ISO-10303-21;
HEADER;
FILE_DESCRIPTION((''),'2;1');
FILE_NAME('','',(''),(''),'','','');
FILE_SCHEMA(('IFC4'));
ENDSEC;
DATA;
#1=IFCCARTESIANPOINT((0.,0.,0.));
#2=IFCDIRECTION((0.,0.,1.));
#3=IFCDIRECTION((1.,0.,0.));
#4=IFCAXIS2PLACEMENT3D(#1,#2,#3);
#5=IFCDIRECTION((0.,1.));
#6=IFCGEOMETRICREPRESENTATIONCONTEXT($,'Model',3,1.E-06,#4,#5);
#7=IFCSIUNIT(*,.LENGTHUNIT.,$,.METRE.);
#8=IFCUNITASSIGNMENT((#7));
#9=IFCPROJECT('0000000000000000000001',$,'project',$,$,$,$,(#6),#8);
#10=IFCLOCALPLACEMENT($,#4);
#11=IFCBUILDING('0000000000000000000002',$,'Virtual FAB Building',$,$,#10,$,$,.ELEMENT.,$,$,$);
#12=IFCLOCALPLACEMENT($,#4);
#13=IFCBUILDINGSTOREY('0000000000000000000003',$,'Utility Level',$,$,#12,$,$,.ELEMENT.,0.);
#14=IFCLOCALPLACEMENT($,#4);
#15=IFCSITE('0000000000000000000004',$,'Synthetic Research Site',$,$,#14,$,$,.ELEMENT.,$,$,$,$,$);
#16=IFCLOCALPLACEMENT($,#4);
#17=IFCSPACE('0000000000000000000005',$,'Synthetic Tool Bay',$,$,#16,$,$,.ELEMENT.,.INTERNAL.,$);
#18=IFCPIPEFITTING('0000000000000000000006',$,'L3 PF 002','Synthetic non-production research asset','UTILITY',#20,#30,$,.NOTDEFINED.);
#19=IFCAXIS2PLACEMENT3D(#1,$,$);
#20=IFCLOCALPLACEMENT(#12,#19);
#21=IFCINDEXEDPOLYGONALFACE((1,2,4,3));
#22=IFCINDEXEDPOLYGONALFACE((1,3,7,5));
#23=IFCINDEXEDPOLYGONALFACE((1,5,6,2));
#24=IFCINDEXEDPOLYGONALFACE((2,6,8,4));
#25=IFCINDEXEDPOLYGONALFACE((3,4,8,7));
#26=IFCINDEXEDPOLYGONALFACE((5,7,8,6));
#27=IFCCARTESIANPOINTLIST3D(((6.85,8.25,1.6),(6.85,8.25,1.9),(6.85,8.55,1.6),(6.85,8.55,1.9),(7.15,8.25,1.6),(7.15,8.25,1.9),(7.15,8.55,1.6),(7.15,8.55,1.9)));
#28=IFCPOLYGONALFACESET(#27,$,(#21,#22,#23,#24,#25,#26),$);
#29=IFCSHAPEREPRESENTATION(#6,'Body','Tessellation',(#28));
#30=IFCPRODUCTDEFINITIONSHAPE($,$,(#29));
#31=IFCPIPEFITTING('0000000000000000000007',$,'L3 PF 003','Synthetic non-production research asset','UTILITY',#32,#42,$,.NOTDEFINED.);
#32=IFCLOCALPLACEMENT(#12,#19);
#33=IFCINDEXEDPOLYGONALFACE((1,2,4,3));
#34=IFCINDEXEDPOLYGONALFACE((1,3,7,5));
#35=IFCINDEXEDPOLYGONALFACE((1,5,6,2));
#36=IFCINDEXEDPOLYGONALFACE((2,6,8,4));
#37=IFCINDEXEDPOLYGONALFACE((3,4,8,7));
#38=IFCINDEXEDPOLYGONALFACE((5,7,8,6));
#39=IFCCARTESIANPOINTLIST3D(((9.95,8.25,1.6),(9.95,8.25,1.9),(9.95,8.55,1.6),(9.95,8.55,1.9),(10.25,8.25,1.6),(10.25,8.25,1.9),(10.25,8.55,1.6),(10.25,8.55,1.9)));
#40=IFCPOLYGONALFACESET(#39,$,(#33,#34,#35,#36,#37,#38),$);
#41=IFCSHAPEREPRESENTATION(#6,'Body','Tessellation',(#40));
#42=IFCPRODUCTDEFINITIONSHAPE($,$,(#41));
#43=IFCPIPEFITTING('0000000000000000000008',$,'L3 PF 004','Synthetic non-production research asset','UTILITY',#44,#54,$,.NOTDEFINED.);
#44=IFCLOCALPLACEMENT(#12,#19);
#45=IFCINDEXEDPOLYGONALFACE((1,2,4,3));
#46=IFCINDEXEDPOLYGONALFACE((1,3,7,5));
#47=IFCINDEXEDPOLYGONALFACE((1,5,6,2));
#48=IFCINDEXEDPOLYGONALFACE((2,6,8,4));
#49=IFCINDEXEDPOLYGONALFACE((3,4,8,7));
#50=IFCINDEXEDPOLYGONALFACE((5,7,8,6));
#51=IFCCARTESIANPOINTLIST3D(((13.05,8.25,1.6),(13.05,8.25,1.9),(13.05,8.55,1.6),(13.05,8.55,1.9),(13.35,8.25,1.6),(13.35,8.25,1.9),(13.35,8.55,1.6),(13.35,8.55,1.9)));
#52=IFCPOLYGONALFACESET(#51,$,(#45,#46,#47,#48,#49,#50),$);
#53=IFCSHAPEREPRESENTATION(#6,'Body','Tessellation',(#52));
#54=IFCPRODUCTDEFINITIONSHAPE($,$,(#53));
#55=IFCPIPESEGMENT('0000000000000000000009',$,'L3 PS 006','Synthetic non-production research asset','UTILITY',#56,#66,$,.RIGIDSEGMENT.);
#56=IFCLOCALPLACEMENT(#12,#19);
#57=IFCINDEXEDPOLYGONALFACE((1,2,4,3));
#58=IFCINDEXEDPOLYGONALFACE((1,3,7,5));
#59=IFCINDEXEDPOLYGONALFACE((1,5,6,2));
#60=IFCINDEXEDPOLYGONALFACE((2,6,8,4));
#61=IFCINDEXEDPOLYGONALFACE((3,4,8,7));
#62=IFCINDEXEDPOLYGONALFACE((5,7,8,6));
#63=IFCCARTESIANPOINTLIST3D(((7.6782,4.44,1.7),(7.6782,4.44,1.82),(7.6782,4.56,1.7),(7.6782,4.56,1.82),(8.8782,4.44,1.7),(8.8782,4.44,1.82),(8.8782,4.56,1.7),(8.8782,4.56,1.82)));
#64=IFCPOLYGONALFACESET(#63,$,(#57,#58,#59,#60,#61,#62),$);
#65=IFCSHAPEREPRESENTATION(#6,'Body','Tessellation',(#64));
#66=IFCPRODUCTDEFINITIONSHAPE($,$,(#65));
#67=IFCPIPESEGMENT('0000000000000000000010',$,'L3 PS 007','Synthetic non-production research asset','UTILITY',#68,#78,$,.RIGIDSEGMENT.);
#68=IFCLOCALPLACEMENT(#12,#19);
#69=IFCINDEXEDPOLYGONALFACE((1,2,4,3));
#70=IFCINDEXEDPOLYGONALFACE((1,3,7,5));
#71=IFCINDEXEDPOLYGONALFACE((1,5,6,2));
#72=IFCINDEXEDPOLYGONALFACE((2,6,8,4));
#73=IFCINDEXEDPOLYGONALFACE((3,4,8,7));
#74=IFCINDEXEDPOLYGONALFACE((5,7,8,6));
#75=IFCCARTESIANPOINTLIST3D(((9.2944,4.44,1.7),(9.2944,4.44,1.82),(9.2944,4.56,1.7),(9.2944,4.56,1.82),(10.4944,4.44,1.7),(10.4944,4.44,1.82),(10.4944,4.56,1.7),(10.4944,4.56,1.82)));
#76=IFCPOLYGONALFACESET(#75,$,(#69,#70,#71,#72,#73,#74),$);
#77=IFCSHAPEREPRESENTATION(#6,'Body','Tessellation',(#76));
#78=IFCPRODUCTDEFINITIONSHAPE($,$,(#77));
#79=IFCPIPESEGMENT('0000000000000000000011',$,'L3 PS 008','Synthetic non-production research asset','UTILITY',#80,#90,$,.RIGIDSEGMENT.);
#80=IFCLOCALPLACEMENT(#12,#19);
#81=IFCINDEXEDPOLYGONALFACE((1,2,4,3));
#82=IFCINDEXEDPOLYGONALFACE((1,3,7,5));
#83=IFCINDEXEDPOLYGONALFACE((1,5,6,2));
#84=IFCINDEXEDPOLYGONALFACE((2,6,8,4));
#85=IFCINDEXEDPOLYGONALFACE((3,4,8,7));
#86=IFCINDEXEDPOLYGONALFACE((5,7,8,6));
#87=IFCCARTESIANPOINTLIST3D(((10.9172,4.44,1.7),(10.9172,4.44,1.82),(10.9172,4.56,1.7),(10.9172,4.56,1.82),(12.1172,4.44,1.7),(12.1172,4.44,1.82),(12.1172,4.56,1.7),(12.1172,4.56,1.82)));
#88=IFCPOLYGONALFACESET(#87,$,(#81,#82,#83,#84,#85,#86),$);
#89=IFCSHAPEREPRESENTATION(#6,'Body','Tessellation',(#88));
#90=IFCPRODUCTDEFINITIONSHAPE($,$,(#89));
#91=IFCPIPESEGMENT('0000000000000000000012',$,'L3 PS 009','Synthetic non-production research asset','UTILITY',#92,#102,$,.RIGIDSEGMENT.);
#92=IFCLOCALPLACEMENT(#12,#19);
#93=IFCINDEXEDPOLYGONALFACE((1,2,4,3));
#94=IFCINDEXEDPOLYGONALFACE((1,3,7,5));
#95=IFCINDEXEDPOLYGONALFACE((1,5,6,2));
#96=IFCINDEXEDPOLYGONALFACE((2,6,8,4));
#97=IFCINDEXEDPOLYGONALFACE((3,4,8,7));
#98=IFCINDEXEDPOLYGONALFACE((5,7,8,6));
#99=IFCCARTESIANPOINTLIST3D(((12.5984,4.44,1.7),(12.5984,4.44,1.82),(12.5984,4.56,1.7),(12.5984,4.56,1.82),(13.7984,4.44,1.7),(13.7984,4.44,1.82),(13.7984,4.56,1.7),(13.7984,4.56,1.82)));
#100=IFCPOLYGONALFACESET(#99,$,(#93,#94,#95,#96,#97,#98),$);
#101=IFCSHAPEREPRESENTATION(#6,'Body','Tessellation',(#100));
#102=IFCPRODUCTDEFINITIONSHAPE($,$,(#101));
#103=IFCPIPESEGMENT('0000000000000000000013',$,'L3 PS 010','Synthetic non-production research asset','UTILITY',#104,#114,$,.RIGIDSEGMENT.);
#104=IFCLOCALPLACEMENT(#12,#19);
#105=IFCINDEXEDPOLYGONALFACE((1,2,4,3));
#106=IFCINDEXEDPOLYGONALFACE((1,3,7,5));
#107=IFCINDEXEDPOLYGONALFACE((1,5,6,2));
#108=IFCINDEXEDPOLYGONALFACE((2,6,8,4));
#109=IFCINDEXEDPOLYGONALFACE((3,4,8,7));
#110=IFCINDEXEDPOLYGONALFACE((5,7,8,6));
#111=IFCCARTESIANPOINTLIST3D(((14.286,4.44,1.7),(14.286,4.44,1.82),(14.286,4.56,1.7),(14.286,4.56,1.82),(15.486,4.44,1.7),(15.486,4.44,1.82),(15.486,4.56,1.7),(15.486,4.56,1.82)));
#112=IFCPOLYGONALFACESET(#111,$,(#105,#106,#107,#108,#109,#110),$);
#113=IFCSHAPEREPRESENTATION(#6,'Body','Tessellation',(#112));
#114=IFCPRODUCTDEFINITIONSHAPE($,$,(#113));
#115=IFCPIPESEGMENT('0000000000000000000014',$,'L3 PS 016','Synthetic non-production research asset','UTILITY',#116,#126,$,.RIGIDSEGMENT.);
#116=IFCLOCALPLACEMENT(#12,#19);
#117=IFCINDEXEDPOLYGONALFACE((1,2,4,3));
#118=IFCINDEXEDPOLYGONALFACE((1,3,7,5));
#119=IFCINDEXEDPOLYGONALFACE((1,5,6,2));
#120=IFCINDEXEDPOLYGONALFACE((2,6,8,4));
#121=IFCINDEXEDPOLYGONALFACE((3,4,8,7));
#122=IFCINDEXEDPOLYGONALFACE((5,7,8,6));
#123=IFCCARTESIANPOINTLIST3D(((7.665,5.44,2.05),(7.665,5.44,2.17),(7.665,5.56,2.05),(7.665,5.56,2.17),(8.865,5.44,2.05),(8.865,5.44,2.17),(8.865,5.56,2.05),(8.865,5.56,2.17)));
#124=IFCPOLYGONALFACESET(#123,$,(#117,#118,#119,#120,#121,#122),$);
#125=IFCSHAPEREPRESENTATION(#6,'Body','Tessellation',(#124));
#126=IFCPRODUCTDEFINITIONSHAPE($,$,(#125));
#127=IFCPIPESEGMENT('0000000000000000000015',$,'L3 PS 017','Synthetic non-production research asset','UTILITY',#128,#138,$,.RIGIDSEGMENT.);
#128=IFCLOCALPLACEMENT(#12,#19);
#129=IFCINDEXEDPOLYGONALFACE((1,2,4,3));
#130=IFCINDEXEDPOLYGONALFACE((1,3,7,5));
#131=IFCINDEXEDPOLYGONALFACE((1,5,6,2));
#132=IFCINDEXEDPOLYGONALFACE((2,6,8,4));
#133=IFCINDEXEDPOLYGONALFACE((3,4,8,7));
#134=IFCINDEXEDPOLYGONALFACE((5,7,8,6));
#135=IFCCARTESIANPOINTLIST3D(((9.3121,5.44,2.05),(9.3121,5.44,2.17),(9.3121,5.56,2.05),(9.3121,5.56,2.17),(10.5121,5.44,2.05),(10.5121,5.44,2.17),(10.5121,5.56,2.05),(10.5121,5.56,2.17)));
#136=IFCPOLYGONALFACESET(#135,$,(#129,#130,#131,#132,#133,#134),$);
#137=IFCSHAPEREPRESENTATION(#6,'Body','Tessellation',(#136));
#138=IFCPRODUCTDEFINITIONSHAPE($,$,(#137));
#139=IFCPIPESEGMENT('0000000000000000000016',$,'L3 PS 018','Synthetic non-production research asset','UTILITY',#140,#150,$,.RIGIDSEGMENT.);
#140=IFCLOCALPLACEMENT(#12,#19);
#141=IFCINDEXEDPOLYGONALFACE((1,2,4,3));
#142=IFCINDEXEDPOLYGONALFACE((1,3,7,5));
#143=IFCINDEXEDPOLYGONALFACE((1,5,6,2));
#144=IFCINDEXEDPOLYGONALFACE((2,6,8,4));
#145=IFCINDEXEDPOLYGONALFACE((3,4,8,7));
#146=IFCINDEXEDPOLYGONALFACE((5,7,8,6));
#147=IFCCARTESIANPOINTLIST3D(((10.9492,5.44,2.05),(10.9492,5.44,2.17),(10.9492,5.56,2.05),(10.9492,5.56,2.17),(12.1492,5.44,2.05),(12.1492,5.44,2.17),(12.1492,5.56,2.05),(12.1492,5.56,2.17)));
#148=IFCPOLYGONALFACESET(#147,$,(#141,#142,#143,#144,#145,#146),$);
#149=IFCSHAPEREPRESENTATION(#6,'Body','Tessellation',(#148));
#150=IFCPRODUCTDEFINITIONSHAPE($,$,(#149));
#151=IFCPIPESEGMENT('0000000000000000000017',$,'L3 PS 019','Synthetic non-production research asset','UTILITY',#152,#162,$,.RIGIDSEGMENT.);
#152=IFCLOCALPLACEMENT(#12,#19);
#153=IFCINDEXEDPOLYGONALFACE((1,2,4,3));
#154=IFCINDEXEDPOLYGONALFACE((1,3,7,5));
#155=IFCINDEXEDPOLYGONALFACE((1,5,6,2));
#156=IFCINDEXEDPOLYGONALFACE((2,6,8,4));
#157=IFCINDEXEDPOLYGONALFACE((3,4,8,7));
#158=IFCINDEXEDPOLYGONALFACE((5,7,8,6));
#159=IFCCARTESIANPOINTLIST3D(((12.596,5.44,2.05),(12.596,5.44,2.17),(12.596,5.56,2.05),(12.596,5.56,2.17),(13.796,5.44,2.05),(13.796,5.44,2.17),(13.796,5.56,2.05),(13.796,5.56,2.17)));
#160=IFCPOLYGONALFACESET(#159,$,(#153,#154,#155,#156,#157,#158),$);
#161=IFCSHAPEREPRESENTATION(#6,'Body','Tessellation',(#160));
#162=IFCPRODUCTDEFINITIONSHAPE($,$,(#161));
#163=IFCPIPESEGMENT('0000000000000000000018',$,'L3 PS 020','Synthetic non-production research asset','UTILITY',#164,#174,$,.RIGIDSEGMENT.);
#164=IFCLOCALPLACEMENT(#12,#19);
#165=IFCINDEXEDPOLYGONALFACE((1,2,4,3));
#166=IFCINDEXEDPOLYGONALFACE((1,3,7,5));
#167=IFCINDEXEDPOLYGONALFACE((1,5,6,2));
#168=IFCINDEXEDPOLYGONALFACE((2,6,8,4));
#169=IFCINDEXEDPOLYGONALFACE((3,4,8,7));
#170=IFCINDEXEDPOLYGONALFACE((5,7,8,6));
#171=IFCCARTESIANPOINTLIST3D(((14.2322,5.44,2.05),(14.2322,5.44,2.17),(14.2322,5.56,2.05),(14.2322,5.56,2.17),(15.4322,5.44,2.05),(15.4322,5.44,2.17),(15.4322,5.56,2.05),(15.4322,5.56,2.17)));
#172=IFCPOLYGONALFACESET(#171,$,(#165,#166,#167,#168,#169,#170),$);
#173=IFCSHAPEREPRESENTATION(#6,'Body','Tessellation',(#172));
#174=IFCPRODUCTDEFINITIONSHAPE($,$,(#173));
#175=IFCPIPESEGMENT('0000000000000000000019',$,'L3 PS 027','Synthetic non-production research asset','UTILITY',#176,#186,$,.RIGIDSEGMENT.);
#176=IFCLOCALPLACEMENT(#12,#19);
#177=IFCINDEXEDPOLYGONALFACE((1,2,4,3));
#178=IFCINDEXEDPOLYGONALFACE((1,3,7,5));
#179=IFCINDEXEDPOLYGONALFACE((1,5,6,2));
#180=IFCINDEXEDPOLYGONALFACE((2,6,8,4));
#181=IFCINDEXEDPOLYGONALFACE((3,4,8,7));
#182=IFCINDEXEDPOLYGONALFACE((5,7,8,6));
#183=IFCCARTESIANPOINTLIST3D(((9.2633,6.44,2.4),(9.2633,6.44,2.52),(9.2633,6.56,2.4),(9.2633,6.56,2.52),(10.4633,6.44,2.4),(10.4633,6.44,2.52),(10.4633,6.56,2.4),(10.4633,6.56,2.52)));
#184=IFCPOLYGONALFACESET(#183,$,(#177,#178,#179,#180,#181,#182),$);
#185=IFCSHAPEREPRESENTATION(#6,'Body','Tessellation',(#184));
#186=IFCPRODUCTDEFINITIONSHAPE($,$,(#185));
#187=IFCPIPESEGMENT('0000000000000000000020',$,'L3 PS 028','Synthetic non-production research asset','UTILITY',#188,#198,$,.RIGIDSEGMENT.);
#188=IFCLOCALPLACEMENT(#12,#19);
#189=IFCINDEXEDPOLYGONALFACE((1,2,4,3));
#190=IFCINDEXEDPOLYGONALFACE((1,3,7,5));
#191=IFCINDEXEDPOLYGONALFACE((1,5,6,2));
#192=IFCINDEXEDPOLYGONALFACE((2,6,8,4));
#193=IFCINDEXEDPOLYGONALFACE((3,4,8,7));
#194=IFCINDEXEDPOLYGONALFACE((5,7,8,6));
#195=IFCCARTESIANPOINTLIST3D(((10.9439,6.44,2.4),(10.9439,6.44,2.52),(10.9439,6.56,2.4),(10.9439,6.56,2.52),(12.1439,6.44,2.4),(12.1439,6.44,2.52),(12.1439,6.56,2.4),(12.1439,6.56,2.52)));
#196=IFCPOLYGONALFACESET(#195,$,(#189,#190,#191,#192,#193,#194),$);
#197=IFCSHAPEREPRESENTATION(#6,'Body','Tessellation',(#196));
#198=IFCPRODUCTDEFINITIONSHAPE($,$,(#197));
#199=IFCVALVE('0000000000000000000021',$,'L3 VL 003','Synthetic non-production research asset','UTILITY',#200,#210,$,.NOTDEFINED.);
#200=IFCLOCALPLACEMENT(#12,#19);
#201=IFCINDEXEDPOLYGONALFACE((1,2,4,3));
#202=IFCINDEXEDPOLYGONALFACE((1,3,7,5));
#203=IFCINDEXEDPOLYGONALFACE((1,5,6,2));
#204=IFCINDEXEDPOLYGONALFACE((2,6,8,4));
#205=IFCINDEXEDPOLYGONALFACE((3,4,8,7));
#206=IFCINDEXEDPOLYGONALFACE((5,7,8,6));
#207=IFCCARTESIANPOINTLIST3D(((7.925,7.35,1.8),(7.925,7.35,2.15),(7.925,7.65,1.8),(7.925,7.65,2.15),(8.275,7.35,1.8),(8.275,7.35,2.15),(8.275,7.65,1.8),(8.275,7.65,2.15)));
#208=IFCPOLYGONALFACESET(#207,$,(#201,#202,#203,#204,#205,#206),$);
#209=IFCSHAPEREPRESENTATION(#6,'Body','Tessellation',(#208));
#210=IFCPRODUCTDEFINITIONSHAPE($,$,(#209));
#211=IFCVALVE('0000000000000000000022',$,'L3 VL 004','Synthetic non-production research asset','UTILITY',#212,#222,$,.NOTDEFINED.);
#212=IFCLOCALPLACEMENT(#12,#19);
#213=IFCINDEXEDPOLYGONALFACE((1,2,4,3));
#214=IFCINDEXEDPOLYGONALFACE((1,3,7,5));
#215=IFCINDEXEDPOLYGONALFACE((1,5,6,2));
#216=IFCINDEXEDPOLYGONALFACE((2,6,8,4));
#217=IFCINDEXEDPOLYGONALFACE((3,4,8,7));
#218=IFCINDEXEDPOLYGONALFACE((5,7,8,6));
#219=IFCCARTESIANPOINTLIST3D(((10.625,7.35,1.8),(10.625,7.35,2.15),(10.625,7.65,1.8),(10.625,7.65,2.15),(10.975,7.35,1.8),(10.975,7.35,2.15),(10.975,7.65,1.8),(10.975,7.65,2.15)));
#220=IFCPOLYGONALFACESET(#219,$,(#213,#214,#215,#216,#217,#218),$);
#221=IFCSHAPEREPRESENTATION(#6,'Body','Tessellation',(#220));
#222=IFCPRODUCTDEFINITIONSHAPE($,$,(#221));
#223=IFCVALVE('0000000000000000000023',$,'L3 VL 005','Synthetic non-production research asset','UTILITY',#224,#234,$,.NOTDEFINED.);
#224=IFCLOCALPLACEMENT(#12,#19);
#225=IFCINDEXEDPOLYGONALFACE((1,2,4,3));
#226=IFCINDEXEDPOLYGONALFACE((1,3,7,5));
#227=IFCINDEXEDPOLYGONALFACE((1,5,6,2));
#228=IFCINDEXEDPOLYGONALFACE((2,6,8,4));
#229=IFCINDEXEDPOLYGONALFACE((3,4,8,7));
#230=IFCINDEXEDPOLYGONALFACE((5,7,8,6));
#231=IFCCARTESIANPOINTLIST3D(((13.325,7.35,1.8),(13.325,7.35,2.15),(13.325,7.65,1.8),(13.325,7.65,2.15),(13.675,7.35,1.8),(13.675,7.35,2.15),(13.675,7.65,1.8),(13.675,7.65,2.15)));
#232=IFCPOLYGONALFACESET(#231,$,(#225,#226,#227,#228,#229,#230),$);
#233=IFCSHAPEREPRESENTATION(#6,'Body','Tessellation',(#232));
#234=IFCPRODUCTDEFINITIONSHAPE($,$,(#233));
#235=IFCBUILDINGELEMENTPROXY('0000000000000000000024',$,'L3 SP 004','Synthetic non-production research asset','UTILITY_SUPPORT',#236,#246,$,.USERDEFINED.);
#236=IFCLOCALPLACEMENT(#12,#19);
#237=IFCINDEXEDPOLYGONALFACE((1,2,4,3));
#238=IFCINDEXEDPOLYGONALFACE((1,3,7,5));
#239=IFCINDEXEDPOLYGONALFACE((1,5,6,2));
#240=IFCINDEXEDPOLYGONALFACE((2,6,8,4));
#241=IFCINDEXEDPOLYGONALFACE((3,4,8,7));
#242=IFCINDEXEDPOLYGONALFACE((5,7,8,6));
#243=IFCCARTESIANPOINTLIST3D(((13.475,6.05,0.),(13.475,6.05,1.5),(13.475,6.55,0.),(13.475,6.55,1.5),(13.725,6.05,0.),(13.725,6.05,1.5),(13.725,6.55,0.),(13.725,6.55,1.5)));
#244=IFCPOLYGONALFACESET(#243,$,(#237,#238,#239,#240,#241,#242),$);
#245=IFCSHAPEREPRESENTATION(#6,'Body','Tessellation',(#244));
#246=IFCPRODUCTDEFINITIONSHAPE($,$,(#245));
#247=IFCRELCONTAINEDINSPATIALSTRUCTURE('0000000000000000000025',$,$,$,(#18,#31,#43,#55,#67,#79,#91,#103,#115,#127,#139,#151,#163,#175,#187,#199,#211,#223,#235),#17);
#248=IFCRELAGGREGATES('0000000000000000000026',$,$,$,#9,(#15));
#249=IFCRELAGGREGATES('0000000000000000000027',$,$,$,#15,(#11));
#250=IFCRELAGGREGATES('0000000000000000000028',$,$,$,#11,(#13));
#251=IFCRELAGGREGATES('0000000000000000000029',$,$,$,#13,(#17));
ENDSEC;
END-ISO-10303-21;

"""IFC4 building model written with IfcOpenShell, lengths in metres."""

from ifc_helpers import new_model, si_unit, direction, frame, origin_with_axes, origin_2d_with_axis, place, context, project, spatial, rectangle, extrude, element, save


model = new_model("IFC4")

# Units and contexts
model_context = context("Model", 3, precision=1e-06, world=origin_with_axes(), true_north=direction((0.0, 1.0)))
ifc_project = project(units=[si_unit("LENGTHUNIT", "METRE")], contexts=[model_context])

# Site, building, storey, space
site_placement = place(None, origin_with_axes())
site = spatial("IfcSite", under=ifc_project, at=site_placement, Name="Synthetic Research Site", CompositionType="ELEMENT")
building_placement = place(None, origin_with_axes())
building = spatial("IfcBuilding", under=site, at=building_placement, Name="Virtual FAB Building", CompositionType="ELEMENT")
storey_placement = place(None, origin_with_axes())
storey = spatial("IfcBuildingStorey", under=building, at=storey_placement, Name="Utility Level", CompositionType="ELEMENT", Elevation=0.0)
space_placement = place(None, origin_with_axes())
space = spatial("IfcSpace", under=storey, at=space_placement, Name="Synthetic Tool Bay", CompositionType="ELEMENT", PredefinedType="INTERNAL")

# Pipe fittings
for number, where, z_axis, x_axis, name in (
    (1, (7.0, 8.4, 1.6), (0.0, 0.0, 1.0), (1.0, 0.0, 0.0), "L3 PF 002"),
    (2, (10.1, 8.4, 1.6), (0.0, 0.0, 1.0), (1.0, 0.0, 0.0), "L3 PF 003"),
    (3, (13.2, 8.4, 1.6), (0.0, 0.0, 1.0), (1.0, 0.0, 0.0), "L3 PF 004"),
):
    element("IfcPipeFitting", number, at=place(None, frame(where, z_axis=z_axis, x_axis=x_axis)), inside=space, Name=name, Description="Synthetic non-production research asset", ObjectType="UTILITY", PredefinedType="NOTDEFINED", context=model_context, shape_type="SweptSolid", body=[
        extrude(rectangle(XDim=0.3, YDim=0.3, at=origin_2d_with_axis()), origin_with_axes(), (0.0, 0.0, 1.0), 0.3),
    ])

# Pipe segments
for number, where, z_axis, x_axis, name in (
    (4, (8.2782, 4.5, 1.7), (0.0, 0.0, 1.0), (1.0, 0.0, 0.0), "L3 PS 006"),
    (5, (9.8944, 4.5, 1.7), (0.0, 0.0, 1.0), (1.0, 0.0, 0.0), "L3 PS 007"),
    (6, (11.5172, 4.5, 1.7), (0.0, 0.0, 1.0), (1.0, 0.0, 0.0), "L3 PS 008"),
    (7, (13.1984, 4.5, 1.7), (0.0, 0.0, 1.0), (1.0, 0.0, 0.0), "L3 PS 009"),
    (8, (14.886, 4.5, 1.7), (0.0, 0.0, 1.0), (1.0, 0.0, 0.0), "L3 PS 010"),
    (9, (8.265, 5.5, 2.05), (0.0, 0.0, 1.0), (1.0, 0.0, 0.0), "L3 PS 016"),
    (10, (9.9121, 5.5, 2.05), (0.0, 0.0, 1.0), (1.0, 0.0, 0.0), "L3 PS 017"),
    (11, (11.5492, 5.5, 2.05), (0.0, 0.0, 1.0), (1.0, 0.0, 0.0), "L3 PS 018"),
    (12, (13.196, 5.5, 2.05), (0.0, 0.0, 1.0), (1.0, 0.0, 0.0), "L3 PS 019"),
    (13, (14.8322, 5.5, 2.05), (0.0, 0.0, 1.0), (1.0, 0.0, 0.0), "L3 PS 020"),
    (14, (9.8633, 6.5, 2.4), (0.0, 0.0, 1.0), (1.0, 0.0, 0.0), "L3 PS 027"),
    (15, (11.5439, 6.5, 2.4), (0.0, 0.0, 1.0), (1.0, 0.0, 0.0), "L3 PS 028"),
):
    element("IfcPipeSegment", number, at=place(None, frame(where, z_axis=z_axis, x_axis=x_axis)), inside=space, Name=name, Description="Synthetic non-production research asset", ObjectType="UTILITY", PredefinedType="RIGIDSEGMENT", context=model_context, shape_type="SweptSolid", body=[
        extrude(rectangle(XDim=1.2, YDim=0.12, at=origin_2d_with_axis()), origin_with_axes(), (0.0, 0.0, 1.0), 0.12),
    ])

# Valves
for number, where, z_axis, x_axis, name in (
    (16, (8.1, 7.5, 1.8), (0.0, 0.0, 1.0), (1.0, 0.0, 0.0), "L3 VL 003"),
    (17, (10.8, 7.5, 1.8), (0.0, 0.0, 1.0), (1.0, 0.0, 0.0), "L3 VL 004"),
    (18, (13.5, 7.5, 1.8), (0.0, 0.0, 1.0), (1.0, 0.0, 0.0), "L3 VL 005"),
):
    element("IfcValve", number, at=place(None, frame(where, z_axis=z_axis, x_axis=x_axis)), inside=space, Name=name, Description="Synthetic non-production research asset", ObjectType="UTILITY", PredefinedType="NOTDEFINED", context=model_context, shape_type="SweptSolid", body=[
        extrude(rectangle(XDim=0.35, YDim=0.3, at=origin_2d_with_axis()), origin_with_axes(), (0.0, 0.0, 1.0), 0.35),
    ])

# Building element proxy
for number, where, z_axis, x_axis, name in (
    (19, (13.6, 6.3, 0.0), (0.0, 0.0, 1.0), (1.0, 0.0, 0.0), "L3 SP 004"),
):
    element("IfcBuildingElementProxy", number, at=place(None, frame(where, z_axis=z_axis, x_axis=x_axis)), inside=space, Name=name, Description="Synthetic non-production research asset", ObjectType="UTILITY_SUPPORT", PredefinedType="USERDEFINED", context=model_context, shape_type="SweptSolid", body=[
        extrude(rectangle(XDim=0.25, YDim=0.5, at=origin_2d_with_axis()), origin_with_axes(), (0.0, 0.0, 1.0), 1.5),
    ])

save(model, "model.ifc")
